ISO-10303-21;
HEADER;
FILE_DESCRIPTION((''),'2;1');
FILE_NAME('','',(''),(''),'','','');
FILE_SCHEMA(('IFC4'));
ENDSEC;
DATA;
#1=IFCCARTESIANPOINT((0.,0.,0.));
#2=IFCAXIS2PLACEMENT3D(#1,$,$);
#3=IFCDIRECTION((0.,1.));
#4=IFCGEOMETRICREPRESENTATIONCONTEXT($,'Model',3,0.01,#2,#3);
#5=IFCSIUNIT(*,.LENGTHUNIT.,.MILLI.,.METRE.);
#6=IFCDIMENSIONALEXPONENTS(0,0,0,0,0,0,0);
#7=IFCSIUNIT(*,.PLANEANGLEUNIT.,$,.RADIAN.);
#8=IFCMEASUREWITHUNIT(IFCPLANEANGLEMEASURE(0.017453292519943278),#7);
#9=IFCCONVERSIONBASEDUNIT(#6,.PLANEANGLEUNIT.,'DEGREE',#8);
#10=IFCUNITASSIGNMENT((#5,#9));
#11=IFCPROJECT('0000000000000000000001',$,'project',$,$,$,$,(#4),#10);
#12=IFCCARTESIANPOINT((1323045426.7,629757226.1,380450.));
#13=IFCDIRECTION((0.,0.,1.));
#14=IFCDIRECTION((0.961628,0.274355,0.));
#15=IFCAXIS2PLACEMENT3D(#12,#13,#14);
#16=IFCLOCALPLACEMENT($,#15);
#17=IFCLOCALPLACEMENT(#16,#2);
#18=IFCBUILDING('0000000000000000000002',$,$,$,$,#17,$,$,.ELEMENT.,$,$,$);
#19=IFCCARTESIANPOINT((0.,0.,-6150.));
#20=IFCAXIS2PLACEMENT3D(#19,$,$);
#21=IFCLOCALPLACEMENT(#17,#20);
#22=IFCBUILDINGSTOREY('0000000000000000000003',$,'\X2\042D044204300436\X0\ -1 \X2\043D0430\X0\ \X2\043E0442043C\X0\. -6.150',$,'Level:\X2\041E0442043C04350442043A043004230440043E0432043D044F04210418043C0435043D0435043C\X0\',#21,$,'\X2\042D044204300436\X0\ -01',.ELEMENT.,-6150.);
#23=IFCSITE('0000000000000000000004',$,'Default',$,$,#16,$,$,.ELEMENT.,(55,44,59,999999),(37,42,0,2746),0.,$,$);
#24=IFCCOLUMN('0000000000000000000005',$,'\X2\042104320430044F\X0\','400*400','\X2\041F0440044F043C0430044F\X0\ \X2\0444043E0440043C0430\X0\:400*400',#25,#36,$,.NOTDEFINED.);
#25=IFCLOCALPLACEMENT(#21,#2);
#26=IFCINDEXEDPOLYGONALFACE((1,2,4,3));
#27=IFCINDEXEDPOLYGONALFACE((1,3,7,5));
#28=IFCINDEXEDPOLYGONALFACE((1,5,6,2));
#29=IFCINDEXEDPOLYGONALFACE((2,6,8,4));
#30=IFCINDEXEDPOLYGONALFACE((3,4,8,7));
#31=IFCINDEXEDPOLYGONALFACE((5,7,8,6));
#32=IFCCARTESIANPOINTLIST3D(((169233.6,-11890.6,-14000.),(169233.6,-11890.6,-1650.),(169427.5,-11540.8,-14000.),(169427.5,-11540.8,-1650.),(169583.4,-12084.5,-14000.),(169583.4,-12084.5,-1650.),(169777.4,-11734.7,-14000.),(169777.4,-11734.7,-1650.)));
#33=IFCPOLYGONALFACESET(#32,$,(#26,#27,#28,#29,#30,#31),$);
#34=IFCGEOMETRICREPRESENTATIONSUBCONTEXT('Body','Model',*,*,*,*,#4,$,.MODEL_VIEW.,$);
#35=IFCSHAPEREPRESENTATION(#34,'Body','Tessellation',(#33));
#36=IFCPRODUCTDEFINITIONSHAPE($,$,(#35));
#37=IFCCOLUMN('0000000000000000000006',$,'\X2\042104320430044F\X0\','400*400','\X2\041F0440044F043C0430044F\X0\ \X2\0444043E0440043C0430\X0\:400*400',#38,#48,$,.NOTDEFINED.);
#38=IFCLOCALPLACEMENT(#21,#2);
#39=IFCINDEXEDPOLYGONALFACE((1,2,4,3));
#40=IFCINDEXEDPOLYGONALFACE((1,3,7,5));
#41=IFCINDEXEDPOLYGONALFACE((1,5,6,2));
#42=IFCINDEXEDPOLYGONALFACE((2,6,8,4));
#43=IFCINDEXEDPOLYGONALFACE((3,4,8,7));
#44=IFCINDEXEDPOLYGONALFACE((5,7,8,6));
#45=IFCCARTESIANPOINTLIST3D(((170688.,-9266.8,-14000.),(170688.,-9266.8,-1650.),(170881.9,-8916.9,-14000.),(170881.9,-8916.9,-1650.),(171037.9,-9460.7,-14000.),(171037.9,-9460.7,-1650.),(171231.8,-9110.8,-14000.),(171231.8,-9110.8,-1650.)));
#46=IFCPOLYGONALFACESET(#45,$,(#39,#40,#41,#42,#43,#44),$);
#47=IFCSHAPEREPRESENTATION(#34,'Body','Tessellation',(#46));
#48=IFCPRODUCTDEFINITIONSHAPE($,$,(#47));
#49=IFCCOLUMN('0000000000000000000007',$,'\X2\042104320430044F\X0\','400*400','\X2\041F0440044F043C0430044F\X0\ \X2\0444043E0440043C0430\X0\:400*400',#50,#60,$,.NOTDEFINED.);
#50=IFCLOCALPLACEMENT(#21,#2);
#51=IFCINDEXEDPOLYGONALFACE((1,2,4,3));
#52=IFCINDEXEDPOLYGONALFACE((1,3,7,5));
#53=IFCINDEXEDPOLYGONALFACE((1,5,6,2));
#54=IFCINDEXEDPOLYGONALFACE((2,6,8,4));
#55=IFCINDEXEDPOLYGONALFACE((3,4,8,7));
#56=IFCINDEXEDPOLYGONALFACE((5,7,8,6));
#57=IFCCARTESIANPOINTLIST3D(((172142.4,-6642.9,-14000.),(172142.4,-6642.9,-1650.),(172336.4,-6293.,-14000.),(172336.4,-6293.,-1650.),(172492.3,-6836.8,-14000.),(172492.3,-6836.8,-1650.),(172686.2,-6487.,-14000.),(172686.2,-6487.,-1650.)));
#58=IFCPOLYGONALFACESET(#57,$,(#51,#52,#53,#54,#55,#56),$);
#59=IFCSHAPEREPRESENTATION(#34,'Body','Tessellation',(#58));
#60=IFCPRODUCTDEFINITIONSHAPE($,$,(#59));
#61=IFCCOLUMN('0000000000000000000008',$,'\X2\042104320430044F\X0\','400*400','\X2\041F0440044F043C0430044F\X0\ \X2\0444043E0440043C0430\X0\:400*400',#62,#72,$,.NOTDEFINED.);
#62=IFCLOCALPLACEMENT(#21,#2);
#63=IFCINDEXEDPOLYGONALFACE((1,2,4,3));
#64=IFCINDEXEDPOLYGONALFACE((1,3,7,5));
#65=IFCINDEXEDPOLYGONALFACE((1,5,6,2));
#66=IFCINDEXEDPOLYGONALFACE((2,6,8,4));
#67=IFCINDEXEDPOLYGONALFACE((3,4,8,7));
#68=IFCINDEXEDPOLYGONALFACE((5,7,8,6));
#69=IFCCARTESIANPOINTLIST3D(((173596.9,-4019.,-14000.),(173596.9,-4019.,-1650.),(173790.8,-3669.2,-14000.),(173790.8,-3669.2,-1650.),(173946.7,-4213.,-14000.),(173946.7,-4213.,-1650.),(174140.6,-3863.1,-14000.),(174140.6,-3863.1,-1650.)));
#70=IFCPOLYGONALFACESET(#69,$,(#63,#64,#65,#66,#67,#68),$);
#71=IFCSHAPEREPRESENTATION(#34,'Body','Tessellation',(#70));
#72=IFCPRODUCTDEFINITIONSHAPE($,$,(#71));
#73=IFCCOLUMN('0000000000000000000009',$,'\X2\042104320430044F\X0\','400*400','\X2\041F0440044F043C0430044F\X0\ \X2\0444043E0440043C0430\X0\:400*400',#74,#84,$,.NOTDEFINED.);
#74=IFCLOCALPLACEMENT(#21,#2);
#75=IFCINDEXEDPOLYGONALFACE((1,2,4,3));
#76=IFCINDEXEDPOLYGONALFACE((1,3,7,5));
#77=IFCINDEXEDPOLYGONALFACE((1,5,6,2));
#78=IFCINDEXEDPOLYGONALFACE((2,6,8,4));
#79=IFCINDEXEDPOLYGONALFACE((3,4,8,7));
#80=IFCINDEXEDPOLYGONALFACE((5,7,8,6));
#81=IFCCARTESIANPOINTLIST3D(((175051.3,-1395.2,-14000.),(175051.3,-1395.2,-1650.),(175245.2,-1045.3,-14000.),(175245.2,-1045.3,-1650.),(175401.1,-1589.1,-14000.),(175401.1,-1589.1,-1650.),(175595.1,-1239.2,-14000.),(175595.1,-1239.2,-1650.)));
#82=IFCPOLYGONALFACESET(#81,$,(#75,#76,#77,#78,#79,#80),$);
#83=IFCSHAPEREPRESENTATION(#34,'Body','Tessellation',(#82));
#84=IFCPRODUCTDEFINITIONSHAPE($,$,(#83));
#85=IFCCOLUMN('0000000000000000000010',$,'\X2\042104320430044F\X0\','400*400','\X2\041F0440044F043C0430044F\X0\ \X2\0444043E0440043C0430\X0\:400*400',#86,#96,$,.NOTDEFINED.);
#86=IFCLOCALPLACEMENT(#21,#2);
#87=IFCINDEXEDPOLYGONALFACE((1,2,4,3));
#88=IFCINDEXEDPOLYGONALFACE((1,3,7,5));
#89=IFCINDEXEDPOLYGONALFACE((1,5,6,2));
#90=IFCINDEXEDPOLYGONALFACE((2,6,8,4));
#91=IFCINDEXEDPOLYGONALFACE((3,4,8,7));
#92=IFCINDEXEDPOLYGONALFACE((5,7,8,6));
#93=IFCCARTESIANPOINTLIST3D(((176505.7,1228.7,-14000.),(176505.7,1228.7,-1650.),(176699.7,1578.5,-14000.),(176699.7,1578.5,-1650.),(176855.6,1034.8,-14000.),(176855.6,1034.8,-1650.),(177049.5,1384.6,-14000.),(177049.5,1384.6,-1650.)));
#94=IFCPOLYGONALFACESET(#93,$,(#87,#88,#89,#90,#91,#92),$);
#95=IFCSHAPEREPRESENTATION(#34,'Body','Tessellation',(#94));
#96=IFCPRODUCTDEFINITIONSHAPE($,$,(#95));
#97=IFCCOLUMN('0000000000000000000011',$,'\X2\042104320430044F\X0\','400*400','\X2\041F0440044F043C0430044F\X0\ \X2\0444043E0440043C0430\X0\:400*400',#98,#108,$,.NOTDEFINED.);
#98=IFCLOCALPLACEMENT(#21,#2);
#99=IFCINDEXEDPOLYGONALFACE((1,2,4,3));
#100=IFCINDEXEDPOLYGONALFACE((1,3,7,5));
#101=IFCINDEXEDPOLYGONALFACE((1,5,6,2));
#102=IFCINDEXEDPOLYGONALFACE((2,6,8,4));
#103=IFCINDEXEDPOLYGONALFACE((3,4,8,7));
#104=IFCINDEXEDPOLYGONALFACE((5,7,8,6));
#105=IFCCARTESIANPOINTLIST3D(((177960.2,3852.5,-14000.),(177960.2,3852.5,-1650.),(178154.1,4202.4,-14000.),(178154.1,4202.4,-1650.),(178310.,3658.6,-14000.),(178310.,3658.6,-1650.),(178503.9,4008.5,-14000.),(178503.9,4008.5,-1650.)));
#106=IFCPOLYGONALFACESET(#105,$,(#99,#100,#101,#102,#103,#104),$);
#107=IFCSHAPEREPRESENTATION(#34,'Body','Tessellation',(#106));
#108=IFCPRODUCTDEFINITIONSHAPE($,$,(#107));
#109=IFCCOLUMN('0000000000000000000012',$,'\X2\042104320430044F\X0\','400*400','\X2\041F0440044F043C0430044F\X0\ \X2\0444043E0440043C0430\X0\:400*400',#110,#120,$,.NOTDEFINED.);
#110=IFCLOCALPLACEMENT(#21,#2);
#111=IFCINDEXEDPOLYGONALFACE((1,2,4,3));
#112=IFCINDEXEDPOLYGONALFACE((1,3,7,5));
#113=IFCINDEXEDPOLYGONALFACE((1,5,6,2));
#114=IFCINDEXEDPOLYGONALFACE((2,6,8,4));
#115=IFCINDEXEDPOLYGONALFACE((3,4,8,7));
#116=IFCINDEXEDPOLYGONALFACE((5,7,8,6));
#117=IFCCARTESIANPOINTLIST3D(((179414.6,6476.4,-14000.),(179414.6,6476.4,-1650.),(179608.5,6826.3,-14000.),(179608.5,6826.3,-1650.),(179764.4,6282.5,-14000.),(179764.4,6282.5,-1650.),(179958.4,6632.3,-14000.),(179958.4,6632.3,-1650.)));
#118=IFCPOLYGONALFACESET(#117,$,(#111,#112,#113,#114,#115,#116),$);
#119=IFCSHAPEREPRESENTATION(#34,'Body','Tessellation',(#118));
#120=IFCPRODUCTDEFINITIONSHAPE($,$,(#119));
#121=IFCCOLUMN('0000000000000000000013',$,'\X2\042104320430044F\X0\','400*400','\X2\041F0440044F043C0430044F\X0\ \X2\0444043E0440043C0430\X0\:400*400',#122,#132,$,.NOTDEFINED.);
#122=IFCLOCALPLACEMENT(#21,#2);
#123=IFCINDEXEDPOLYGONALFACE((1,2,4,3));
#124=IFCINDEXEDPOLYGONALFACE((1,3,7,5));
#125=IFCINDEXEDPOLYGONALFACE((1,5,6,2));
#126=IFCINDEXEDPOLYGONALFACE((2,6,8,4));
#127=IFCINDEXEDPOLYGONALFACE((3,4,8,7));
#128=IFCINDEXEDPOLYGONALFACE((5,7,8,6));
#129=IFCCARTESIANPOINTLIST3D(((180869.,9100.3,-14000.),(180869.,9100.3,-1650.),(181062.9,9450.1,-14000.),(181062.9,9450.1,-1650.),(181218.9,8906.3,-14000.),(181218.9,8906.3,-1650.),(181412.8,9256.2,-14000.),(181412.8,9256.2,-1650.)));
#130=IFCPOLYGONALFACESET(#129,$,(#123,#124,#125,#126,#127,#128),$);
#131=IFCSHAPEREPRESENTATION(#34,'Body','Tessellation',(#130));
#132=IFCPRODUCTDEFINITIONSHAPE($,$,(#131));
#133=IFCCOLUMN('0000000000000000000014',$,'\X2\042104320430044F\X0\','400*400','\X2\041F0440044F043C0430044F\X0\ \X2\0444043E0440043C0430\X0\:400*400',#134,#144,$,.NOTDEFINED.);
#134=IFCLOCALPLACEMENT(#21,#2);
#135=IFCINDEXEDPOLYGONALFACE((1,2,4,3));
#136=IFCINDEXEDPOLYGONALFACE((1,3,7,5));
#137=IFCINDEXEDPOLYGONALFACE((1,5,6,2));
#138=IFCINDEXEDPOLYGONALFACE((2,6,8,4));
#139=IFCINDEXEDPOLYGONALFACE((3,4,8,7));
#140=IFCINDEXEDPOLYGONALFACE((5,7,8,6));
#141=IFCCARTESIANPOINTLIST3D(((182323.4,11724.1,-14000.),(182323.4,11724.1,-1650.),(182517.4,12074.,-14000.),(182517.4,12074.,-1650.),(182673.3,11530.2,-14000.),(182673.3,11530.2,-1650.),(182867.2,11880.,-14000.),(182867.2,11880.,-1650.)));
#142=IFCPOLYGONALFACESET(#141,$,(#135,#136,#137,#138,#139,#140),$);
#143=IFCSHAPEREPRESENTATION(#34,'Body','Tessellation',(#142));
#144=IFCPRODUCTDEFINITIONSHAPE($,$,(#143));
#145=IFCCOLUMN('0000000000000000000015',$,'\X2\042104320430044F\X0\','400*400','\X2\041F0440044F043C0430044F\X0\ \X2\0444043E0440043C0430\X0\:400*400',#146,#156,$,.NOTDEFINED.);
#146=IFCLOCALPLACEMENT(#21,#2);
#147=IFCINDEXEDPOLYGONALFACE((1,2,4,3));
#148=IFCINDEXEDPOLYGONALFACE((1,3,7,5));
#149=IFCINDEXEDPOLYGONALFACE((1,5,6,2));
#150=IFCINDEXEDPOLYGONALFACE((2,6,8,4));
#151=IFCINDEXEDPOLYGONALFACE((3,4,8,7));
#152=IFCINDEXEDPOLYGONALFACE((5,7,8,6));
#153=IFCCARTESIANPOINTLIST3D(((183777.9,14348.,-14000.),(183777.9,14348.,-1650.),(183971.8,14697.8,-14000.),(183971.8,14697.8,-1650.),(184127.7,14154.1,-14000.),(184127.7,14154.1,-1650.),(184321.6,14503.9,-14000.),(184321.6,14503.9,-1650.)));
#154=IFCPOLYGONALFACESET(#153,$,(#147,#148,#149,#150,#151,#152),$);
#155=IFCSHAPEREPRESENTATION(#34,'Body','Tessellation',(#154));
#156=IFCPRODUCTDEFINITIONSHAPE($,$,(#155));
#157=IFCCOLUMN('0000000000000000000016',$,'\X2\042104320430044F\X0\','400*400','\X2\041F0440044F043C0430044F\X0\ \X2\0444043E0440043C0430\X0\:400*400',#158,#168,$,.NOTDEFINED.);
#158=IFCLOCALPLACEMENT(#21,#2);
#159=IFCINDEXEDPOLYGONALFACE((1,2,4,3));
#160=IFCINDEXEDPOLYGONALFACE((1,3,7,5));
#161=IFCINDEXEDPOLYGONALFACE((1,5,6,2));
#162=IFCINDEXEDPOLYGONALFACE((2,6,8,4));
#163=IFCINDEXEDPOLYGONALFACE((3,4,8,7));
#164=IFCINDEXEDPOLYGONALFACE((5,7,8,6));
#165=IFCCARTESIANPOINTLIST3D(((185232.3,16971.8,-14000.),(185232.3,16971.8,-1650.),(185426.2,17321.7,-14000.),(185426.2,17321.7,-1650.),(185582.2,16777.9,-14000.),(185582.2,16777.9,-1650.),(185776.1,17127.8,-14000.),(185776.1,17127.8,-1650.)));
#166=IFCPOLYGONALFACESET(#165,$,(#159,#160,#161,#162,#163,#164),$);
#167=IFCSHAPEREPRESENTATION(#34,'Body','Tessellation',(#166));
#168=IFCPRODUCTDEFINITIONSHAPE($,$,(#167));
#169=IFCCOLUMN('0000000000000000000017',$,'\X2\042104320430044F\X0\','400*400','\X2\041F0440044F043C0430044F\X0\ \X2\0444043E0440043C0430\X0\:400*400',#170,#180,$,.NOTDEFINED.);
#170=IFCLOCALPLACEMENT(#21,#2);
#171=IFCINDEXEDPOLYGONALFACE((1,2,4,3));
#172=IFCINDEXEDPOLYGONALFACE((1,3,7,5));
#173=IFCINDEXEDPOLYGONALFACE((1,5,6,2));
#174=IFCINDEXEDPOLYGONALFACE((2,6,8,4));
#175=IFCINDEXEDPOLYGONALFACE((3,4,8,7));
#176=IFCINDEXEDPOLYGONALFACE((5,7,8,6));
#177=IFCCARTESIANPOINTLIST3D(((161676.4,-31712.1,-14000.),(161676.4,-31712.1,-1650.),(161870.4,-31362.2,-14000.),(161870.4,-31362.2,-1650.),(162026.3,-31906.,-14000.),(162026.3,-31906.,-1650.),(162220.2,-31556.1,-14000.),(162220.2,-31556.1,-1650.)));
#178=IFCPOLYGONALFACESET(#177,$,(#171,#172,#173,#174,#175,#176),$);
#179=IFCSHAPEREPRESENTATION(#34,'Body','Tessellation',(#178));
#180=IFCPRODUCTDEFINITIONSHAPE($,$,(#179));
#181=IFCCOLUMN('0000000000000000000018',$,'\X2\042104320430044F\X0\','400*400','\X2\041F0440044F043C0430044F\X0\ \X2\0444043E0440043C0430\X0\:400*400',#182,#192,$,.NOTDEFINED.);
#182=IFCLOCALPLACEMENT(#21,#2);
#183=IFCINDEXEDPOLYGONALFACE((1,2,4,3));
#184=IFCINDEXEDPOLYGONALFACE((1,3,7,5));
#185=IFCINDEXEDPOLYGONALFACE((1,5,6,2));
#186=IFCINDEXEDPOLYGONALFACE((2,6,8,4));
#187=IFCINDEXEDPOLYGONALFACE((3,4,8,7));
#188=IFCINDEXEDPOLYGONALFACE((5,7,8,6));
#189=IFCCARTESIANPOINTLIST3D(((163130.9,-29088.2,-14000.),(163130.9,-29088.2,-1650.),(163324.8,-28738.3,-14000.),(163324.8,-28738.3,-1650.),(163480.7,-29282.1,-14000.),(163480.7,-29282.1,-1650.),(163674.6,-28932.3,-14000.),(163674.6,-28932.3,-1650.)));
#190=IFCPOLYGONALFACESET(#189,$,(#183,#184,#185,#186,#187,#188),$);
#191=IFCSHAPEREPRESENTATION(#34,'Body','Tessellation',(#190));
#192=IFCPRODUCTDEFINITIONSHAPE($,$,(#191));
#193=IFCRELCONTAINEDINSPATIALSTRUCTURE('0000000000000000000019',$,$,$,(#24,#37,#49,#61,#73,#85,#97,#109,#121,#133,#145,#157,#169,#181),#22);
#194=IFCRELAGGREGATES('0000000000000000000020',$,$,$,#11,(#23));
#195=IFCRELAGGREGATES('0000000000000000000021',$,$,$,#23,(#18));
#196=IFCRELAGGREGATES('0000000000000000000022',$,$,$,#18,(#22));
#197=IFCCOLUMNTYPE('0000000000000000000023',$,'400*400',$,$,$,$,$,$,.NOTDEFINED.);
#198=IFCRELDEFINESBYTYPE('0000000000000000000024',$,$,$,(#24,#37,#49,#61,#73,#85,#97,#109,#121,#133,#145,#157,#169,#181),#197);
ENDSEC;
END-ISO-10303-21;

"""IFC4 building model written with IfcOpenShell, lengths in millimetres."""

from ifc_helpers import new_model, entity, si_unit, converted_unit, direction, frame, origin, place, context, subcontext, project, spatial, indexed_curve, outline, extrude, type_object, element, save


model = new_model("IFC4")

# Units and contexts
model_context = context("Model", 3, precision=0.01, world=origin(), true_north=direction((0.0, 1.0)))
body_context = subcontext(model_context, "Body", "Model", "MODEL_VIEW")
ifc_project = project(units=[si_unit("LENGTHUNIT", "METRE", prefix="MILLI"), converted_unit("PLANEANGLEUNIT", "DEGREE", entity("IfcPlaneAngleMeasure", 0.017453292519943278), si_unit("PLANEANGLEUNIT", "RADIAN"), dimensions=[0, 0, 0, 0, 0, 0, 0])], contexts=[model_context])

# Site, building, storey
site_placement = place(None, frame((1323045426.7, 629757226.1, 380450.0), z_axis=(0.0, 0.0, 1.0), x_axis=(0.961628, 0.274355, 0.0)))
site = spatial("IfcSite", under=ifc_project, at=site_placement, Name="Default", CompositionType="ELEMENT", RefLatitude=(55, 44, 59, 999999), RefLongitude=(37, 42, 0, 2746), RefElevation=0.0)
building_placement = place(site_placement, origin())
building = spatial("IfcBuilding", under=site, at=building_placement, CompositionType="ELEMENT")
storey_placement = place(building_placement, frame((0.0, 0.0, -6150.0)))
storey = spatial("IfcBuildingStorey", under=building, at=storey_placement, Name="Этаж -1 на отм. -6.150", ObjectType="Level:ОтметкаУровняСИменем", LongName="Этаж -01", CompositionType="ELEMENT", Elevation=-6150.0)

# Columns
column_type = type_object("IfcColumnType", Name="400*400", PredefinedType="NOTDEFINED")
column_1_placement = place(storey_placement, origin())
element("IfcColumn", 1, at=column_1_placement, inside=storey, type_object=column_type, Name="Свая", Description="400*400", ObjectType="Прямая форма:400*400", PredefinedType="NOTDEFINED", context=body_context, shape_type="SweptSolid", body=[
    extrude(outline(indexed_curve([(-200.0, -200.0), (200.0, -200.0), (200.0, 200.0), (-200.0, 200.0), (-200.0, -200.0)], self_intersect=False)), frame((169505.5, -11812.6, -14000.0), z_axis=(0.0, 0.0, 1.0), x_axis=(0.48481, 0.87462, 0.0)), (0.0, 0.0, 1.0), 12350.0),
])
column_2_placement = place(storey_placement, origin())
element("IfcColumn", 2, at=column_2_placement, inside=storey, type_object=column_type, Name="Свая", Description="400*400", ObjectType="Прямая форма:400*400", PredefinedType="NOTDEFINED", context=body_context, shape_type="SweptSolid", body=[
    extrude(outline(indexed_curve([(-200.0, -200.0), (200.0, -200.0), (200.0, 200.0), (-200.0, 200.0), (-200.0, -200.0)], self_intersect=False)), frame((170959.9, -9188.8, -14000.0), z_axis=(0.0, 0.0, 1.0), x_axis=(0.48481, 0.87462, 0.0)), (0.0, 0.0, 1.0), 12350.0),
])
column_3_placement = place(storey_placement, origin())
element("IfcColumn", 3, at=column_3_placement, inside=storey, type_object=column_type, Name="Свая", Description="400*400", ObjectType="Прямая форма:400*400", PredefinedType="NOTDEFINED", context=body_context, shape_type="SweptSolid", body=[
    extrude(outline(indexed_curve([(-200.0, -200.0), (200.0, -200.0), (200.0, 200.0), (-200.0, 200.0), (-200.0, -200.0)], self_intersect=False)), frame((172414.3, -6564.9, -14000.0), z_axis=(0.0, 0.0, 1.0), x_axis=(0.48481, 0.87462, 0.0)), (0.0, 0.0, 1.0), 12350.0),
])
column_4_placement = place(storey_placement, origin())
element("IfcColumn", 4, at=column_4_placement, inside=storey, type_object=column_type, Name="Свая", Description="400*400", ObjectType="Прямая форма:400*400", PredefinedType="NOTDEFINED", context=body_context, shape_type="SweptSolid", body=[
    extrude(outline(indexed_curve([(-200.0, -200.0), (200.0, -200.0), (200.0, 200.0), (-200.0, 200.0), (-200.0, -200.0)], self_intersect=False)), frame((173868.8, -3941.1, -14000.0), z_axis=(0.0, 0.0, 1.0), x_axis=(0.48481, 0.87462, 0.0)), (0.0, 0.0, 1.0), 12350.0),
])
column_5_placement = place(storey_placement, origin())
element("IfcColumn", 5, at=column_5_placement, inside=storey, type_object=column_type, Name="Свая", Description="400*400", ObjectType="Прямая форма:400*400", PredefinedType="NOTDEFINED", context=body_context, shape_type="SweptSolid", body=[
    extrude(outline(indexed_curve([(-200.0, -200.0), (200.0, -200.0), (200.0, 200.0), (-200.0, 200.0), (-200.0, -200.0)], self_intersect=False)), frame((175323.2, -1317.2, -14000.0), z_axis=(0.0, 0.0, 1.0), x_axis=(0.48481, 0.87462, 0.0)), (0.0, 0.0, 1.0), 12350.0),
])
column_6_placement = place(storey_placement, origin())
element("IfcColumn", 6, at=column_6_placement, inside=storey, type_object=column_type, Name="Свая", Description="400*400", ObjectType="Прямая форма:400*400", PredefinedType="NOTDEFINED", context=body_context, shape_type="SweptSolid", body=[
    extrude(outline(indexed_curve([(-200.0, -200.0), (200.0, -200.0), (200.0, 200.0), (-200.0, 200.0), (-200.0, -200.0)], self_intersect=False)), frame((176777.6, 1306.6, -14000.0), z_axis=(0.0, 0.0, 1.0), x_axis=(0.48481, 0.87462, 0.0)), (0.0, 0.0, 1.0), 12350.0),
])
column_7_placement = place(storey_placement, origin())
element("IfcColumn", 7, at=column_7_placement, inside=storey, type_object=column_type, Name="Свая", Description="400*400", ObjectType="Прямая форма:400*400", PredefinedType="NOTDEFINED", context=body_context, shape_type="SweptSolid", body=[
    extrude(outline(indexed_curve([(-200.0, -200.0), (200.0, -200.0), (200.0, 200.0), (-200.0, 200.0), (-200.0, -200.0)], self_intersect=False)), frame((178232.0, 3930.5, -14000.0), z_axis=(0.0, 0.0, 1.0), x_axis=(0.48481, 0.87462, 0.0)), (0.0, 0.0, 1.0), 12350.0),
])
column_8_placement = place(storey_placement, origin())
element("IfcColumn", 8, at=column_8_placement, inside=storey, type_object=column_type, Name="Свая", Description="400*400", ObjectType="Прямая форма:400*400", PredefinedType="NOTDEFINED", context=body_context, shape_type="SweptSolid", body=[
    extrude(outline(indexed_curve([(-200.0, -200.0), (200.0, -200.0), (200.0, 200.0), (-200.0, 200.0), (-200.0, -200.0)], self_intersect=False)), frame((179686.5, 6554.4, -14000.0), z_axis=(0.0, 0.0, 1.0), x_axis=(0.48481, 0.87462, 0.0)), (0.0, 0.0, 1.0), 12350.0),
])
column_9_placement = place(storey_placement, origin())
element("IfcColumn", 9, at=column_9_placement, inside=storey, type_object=column_type, Name="Свая", Description="400*400", ObjectType="Прямая форма:400*400", PredefinedType="NOTDEFINED", context=body_context, shape_type="SweptSolid", body=[
    extrude(outline(indexed_curve([(-200.0, -200.0), (200.0, -200.0), (200.0, 200.0), (-200.0, 200.0), (-200.0, -200.0)], self_intersect=False)), frame((181140.9, 9178.2, -14000.0), z_axis=(0.0, 0.0, 1.0), x_axis=(0.48481, 0.87462, 0.0)), (0.0, 0.0, 1.0), 12350.0),
])
column_10_placement = place(storey_placement, origin())
element("IfcColumn", 10, at=column_10_placement, inside=storey, type_object=column_type, Name="Свая", Description="400*400", ObjectType="Прямая форма:400*400", PredefinedType="NOTDEFINED", context=body_context, shape_type="SweptSolid", body=[
    extrude(outline(indexed_curve([(-200.0, -200.0), (200.0, -200.0), (200.0, 200.0), (-200.0, 200.0), (-200.0, -200.0)], self_intersect=False)), frame((182595.3, 11802.1, -14000.0), z_axis=(0.0, 0.0, 1.0), x_axis=(0.48481, 0.87462, 0.0)), (0.0, 0.0, 1.0), 12350.0),
])
column_11_placement = place(storey_placement, origin())
element("IfcColumn", 11, at=column_11_placement, inside=storey, type_object=column_type, Name="Свая", Description="400*400", ObjectType="Прямая форма:400*400", PredefinedType="NOTDEFINED", context=body_context, shape_type="SweptSolid", body=[
    extrude(outline(indexed_curve([(-200.0, -200.0), (200.0, -200.0), (200.0, 200.0), (-200.0, 200.0), (-200.0, -200.0)], self_intersect=False)), frame((184049.8, 14425.9, -14000.0), z_axis=(0.0, 0.0, 1.0), x_axis=(0.48481, 0.87462, 0.0)), (0.0, 0.0, 1.0), 12350.0),
])
column_12_placement = place(storey_placement, origin())
element("IfcColumn", 12, at=column_12_placement, inside=storey, type_object=column_type, Name="Свая", Description="400*400", ObjectType="Прямая форма:400*400", PredefinedType="NOTDEFINED", context=body_context, shape_type="SweptSolid", body=[
    extrude(outline(indexed_curve([(-200.0, -200.0), (200.0, -200.0), (200.0, 200.0), (-200.0, 200.0), (-200.0, -200.0)], self_intersect=False)), frame((185504.2, 17049.8, -14000.0), z_axis=(0.0, 0.0, 1.0), x_axis=(0.48481, 0.87462, 0.0)), (0.0, 0.0, 1.0), 12350.0),
])
column_13_placement = place(storey_placement, origin())
element("IfcColumn", 13, at=column_13_placement, inside=storey, type_object=column_type, Name="Свая", Description="400*400", ObjectType="Прямая форма:400*400", PredefinedType="NOTDEFINED", context=body_context, shape_type="SweptSolid", body=[
    extrude(outline(indexed_curve([(-200.0, -200.0), (200.0, -200.0), (200.0, 200.0), (-200.0, 200.0), (-200.0, -200.0)], self_intersect=False)), frame((161948.3, -31634.1, -14000.0), z_axis=(0.0, 0.0, 1.0), x_axis=(0.48481, 0.87462, 0.0)), (0.0, 0.0, 1.0), 12350.0),
])
column_14_placement = place(storey_placement, origin())
element("IfcColumn", 14, at=column_14_placement, inside=storey, type_object=column_type, Name="Свая", Description="400*400", ObjectType="Прямая форма:400*400", PredefinedType="NOTDEFINED", context=body_context, shape_type="SweptSolid", body=[
    extrude(outline(indexed_curve([(-200.0, -200.0), (200.0, -200.0), (200.0, 200.0), (-200.0, 200.0), (-200.0, -200.0)], self_intersect=False)), frame((163402.8, -29010.2, -14000.0), z_axis=(0.0, 0.0, 1.0), x_axis=(0.48481, 0.87462, 0.0)), (0.0, 0.0, 1.0), 12350.0),
])

save(model, "model.ifc")
